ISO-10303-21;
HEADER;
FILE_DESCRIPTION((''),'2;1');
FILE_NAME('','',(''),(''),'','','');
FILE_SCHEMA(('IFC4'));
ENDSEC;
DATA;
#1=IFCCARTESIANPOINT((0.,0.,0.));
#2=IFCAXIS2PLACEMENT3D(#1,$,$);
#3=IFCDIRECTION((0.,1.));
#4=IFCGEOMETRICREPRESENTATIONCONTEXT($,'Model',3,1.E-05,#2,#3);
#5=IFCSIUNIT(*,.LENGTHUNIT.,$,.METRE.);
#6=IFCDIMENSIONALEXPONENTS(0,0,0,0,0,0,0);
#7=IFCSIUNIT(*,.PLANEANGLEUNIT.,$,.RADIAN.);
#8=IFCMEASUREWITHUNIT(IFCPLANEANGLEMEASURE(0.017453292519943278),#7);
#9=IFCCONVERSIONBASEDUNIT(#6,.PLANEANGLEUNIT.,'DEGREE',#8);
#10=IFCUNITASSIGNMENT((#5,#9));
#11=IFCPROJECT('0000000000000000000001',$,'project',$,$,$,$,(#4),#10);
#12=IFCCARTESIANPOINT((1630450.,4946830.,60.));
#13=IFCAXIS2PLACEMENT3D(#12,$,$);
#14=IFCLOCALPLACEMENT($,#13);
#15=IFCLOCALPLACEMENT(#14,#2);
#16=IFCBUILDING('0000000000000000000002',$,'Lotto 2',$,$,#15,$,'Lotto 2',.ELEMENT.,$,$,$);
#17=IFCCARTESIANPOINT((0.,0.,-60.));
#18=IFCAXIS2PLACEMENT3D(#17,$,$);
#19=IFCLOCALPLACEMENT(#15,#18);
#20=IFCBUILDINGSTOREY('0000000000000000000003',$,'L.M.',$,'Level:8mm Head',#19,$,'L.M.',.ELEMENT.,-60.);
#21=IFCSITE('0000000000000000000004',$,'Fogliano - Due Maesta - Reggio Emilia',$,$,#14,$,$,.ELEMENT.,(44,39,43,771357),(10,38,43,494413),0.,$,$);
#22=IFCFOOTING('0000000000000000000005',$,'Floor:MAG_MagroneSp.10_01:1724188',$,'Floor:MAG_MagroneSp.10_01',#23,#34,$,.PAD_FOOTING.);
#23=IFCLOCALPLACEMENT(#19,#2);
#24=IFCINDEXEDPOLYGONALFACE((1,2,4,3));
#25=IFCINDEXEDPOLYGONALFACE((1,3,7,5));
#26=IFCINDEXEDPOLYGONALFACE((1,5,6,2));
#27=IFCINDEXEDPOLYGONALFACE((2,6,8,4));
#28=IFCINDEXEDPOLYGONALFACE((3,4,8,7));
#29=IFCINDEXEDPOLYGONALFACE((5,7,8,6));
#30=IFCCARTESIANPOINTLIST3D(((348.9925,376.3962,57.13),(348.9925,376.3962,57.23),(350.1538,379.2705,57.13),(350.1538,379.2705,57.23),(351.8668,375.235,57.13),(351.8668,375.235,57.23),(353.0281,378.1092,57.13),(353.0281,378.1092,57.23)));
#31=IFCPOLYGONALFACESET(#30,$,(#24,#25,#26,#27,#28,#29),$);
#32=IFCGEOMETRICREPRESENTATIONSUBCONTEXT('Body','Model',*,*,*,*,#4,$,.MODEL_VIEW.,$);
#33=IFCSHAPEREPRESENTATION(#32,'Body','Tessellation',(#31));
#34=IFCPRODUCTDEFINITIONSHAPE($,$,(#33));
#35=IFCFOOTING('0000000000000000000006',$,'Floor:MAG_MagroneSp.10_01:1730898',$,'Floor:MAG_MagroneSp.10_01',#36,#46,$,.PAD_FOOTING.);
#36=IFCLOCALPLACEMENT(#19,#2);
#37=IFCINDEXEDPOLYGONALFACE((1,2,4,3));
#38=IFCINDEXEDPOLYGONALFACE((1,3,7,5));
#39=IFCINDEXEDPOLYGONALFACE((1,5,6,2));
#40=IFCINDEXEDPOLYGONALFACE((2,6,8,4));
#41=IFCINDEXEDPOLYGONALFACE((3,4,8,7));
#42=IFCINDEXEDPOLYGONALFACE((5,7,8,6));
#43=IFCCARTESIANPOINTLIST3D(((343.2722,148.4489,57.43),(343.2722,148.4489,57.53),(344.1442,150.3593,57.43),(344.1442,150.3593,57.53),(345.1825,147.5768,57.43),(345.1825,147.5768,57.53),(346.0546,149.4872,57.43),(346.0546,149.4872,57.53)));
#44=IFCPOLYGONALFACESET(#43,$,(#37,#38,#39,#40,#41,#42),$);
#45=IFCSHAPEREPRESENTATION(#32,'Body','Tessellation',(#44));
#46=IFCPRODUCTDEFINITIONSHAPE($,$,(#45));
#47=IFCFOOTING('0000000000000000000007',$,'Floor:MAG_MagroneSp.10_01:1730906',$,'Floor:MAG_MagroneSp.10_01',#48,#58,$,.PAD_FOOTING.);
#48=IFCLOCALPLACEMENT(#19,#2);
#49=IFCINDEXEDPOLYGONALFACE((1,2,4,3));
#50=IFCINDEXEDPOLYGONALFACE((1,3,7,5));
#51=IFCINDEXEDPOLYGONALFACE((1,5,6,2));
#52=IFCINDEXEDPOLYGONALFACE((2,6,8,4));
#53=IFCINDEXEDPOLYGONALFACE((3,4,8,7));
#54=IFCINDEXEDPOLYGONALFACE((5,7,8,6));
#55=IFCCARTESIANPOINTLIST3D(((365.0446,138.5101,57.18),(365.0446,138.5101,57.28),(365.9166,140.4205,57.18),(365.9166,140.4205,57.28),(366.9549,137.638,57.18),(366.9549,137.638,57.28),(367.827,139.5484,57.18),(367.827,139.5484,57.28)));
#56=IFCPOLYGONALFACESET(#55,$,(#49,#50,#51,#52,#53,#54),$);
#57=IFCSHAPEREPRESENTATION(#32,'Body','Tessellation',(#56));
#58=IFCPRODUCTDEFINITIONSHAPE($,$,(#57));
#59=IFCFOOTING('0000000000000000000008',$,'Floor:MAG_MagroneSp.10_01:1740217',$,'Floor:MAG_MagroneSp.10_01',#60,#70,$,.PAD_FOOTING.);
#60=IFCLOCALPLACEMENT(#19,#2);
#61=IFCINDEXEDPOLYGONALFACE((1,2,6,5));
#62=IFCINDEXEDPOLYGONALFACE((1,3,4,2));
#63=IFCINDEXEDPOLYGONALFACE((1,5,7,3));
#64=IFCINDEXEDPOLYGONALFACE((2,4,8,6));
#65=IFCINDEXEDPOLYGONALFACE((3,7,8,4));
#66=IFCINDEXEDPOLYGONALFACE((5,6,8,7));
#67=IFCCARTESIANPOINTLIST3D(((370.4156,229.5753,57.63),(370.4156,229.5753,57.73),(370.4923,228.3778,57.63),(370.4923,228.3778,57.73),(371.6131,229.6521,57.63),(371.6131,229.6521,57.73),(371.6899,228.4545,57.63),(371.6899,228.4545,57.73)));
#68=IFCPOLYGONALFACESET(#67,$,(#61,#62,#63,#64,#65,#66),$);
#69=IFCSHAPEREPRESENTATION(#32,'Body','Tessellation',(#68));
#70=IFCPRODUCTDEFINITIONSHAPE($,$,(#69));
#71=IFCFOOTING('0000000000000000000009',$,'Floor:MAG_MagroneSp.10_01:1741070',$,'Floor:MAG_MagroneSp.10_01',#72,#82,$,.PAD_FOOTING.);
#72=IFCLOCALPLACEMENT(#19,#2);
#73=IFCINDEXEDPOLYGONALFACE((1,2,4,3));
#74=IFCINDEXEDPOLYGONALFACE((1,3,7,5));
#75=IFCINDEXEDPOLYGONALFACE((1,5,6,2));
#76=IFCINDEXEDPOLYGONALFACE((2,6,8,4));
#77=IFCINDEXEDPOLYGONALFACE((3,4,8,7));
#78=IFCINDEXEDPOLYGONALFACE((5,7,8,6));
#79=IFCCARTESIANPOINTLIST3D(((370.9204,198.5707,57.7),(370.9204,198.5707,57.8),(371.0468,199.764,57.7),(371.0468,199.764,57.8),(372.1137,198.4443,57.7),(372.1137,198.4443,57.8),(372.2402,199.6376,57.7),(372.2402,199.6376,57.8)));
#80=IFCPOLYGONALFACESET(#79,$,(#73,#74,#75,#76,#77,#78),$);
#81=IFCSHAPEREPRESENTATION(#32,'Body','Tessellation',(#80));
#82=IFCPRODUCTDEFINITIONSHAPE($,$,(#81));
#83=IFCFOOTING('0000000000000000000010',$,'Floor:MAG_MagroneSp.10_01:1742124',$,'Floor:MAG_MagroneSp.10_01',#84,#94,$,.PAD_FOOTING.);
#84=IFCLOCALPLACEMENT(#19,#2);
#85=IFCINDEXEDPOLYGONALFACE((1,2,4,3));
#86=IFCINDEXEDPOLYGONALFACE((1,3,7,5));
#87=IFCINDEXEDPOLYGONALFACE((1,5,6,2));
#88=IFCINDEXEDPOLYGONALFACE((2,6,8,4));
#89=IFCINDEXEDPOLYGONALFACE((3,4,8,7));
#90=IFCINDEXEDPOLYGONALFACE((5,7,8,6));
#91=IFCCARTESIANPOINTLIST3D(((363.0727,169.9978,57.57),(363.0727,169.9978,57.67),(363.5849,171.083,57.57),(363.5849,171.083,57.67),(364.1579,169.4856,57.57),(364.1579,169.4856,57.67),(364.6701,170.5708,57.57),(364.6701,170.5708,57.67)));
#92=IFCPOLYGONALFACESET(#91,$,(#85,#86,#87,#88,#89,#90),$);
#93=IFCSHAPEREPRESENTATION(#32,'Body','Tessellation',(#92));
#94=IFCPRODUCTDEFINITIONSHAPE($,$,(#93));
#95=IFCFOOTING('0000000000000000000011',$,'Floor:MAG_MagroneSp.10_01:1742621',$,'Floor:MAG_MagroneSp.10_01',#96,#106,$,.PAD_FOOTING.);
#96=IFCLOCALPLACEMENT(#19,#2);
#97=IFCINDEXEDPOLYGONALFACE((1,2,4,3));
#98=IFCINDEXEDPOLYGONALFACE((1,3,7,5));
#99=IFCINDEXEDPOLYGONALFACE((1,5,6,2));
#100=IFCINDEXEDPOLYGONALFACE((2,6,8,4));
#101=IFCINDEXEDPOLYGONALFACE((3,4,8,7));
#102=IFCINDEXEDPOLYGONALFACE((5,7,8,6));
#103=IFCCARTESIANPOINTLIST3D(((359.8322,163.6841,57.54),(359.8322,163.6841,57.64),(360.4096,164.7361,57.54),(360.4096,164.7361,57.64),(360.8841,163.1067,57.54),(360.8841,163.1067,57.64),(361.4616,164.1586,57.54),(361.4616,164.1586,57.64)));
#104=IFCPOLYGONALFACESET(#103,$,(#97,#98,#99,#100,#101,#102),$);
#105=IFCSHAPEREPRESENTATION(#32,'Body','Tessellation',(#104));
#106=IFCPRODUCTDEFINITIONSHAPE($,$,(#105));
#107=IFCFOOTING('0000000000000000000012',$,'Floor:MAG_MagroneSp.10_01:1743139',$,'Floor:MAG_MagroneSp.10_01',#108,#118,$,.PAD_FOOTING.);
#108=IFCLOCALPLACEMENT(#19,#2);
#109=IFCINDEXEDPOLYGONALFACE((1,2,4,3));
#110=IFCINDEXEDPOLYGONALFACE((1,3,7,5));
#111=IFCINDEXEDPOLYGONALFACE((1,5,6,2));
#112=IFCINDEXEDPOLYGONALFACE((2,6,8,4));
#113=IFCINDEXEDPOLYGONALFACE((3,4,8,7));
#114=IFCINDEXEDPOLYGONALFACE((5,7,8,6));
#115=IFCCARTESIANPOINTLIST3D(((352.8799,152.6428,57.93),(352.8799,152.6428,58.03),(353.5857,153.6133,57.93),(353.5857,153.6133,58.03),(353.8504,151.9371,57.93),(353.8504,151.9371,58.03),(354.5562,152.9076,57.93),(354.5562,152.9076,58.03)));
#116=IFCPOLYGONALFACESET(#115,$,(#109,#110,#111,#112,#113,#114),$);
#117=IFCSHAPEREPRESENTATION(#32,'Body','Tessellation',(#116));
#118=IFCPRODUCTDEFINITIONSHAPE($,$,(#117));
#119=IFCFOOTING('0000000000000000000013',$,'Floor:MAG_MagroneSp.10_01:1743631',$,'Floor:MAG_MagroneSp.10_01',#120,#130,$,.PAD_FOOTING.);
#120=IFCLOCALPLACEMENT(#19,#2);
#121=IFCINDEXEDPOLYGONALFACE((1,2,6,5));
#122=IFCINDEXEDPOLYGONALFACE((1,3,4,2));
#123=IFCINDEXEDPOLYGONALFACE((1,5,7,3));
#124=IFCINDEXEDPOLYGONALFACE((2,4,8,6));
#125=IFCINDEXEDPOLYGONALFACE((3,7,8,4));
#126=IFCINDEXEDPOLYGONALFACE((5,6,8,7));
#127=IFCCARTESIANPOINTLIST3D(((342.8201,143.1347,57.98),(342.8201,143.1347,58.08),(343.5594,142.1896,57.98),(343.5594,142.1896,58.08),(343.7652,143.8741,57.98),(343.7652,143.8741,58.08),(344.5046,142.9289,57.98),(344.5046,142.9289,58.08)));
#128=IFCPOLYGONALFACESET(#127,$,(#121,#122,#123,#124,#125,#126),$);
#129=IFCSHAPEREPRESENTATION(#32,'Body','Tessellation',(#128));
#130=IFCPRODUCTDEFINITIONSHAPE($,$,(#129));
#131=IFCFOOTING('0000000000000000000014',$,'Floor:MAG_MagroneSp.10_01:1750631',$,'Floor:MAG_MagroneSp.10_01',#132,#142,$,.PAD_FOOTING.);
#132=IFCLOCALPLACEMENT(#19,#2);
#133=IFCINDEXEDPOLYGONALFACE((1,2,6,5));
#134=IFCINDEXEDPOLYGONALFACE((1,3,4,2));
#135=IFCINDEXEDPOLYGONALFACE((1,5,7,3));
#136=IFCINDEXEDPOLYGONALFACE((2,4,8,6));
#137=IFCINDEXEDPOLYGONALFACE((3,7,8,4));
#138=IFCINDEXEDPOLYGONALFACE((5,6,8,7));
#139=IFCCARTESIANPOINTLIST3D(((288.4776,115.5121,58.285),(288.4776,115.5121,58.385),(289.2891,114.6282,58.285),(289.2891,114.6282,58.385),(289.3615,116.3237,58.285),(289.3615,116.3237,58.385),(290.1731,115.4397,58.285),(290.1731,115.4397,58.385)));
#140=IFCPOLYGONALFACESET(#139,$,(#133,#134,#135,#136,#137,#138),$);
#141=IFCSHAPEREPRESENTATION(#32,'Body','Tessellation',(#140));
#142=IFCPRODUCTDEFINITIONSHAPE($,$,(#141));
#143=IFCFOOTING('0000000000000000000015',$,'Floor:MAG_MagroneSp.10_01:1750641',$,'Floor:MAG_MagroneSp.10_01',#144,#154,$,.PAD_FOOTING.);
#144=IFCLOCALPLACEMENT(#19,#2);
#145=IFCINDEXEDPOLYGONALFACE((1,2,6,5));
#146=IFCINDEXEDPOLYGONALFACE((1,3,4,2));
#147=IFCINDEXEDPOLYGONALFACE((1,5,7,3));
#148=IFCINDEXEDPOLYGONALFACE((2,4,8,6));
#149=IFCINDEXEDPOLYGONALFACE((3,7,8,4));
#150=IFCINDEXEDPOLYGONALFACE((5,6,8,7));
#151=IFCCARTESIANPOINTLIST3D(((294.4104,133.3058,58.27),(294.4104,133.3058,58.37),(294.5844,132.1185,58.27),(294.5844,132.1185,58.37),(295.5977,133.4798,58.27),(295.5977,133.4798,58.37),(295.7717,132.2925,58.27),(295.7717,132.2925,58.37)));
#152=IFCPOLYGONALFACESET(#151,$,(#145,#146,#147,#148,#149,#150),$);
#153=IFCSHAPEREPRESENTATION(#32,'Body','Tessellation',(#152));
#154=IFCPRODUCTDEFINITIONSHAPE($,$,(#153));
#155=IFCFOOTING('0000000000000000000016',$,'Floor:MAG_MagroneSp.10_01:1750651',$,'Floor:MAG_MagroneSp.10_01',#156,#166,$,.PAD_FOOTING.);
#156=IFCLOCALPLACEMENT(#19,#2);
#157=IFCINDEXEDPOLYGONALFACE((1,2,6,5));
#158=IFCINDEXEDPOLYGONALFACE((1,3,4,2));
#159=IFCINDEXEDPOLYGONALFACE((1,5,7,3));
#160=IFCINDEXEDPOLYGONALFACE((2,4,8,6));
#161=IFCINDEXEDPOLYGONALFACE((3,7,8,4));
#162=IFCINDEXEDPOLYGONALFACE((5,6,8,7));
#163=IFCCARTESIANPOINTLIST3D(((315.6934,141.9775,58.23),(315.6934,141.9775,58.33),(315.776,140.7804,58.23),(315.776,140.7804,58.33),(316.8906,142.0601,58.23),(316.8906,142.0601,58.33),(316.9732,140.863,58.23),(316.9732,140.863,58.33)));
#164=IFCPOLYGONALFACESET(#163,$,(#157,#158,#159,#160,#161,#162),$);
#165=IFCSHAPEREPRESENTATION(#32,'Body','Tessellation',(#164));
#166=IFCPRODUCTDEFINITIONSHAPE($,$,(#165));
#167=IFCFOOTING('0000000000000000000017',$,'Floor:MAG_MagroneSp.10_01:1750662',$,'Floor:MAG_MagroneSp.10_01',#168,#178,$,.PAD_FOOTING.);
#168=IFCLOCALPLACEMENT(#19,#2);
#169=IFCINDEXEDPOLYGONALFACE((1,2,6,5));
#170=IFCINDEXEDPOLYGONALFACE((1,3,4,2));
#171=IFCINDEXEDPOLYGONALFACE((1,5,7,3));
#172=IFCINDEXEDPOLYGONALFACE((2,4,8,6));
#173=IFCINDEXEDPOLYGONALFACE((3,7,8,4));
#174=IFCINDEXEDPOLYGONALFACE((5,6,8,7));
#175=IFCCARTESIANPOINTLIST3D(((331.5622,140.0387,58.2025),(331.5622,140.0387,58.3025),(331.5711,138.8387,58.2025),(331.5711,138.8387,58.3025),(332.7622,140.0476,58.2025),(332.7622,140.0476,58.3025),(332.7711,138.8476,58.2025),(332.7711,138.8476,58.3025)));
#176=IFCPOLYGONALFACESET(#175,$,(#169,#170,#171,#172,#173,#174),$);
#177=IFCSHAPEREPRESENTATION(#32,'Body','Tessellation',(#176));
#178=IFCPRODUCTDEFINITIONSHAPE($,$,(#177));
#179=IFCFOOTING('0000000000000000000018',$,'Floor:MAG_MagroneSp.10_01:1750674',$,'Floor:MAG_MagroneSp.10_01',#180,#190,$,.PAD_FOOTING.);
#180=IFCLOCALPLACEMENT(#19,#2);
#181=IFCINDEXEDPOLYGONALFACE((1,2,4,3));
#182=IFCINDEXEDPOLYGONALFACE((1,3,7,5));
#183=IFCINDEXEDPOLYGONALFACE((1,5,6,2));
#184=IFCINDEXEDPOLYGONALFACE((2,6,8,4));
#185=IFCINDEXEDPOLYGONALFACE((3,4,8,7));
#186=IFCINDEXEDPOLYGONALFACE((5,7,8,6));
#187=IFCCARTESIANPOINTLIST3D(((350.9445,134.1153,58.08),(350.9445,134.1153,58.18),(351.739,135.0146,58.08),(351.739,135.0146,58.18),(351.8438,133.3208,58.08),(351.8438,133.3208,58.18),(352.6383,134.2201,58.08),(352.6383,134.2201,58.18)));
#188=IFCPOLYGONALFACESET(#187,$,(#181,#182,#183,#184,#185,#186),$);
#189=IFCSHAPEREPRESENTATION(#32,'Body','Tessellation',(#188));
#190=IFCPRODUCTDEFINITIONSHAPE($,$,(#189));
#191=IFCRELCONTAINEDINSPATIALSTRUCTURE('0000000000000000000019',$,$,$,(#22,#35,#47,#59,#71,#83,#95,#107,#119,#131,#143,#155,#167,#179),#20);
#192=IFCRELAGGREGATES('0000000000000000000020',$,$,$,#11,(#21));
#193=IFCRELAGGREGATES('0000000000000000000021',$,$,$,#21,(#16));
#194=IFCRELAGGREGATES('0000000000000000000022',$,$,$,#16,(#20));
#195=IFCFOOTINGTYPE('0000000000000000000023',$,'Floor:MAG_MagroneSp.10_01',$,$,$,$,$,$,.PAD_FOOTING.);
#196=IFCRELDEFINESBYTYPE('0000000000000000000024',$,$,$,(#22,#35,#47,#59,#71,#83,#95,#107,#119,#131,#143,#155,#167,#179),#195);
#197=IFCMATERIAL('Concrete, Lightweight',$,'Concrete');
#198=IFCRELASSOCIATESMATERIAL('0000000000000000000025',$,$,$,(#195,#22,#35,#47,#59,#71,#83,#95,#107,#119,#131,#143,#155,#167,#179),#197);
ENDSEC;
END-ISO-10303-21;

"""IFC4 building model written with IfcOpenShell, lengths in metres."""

from ifc_helpers import new_model, entity, si_unit, converted_unit, direction, frame, origin, place, context, subcontext, project, spatial, indexed_curve, outline, extrude, material, type_object, element, save


model = new_model("IFC4")

# Units and contexts
model_context = context("Model", 3, precision=1e-05, world=origin(), true_north=direction((0.0, 1.0)))
body_context = subcontext(model_context, "Body", "Model", "MODEL_VIEW")
ifc_project = project(units=[si_unit("LENGTHUNIT", "METRE"), converted_unit("PLANEANGLEUNIT", "DEGREE", entity("IfcPlaneAngleMeasure", 0.017453292519943278), si_unit("PLANEANGLEUNIT", "RADIAN"), dimensions=[0, 0, 0, 0, 0, 0, 0])], contexts=[model_context])

# Site, building, storey
site_placement = place(None, frame((1630450.0, 4946830.0, 60.0)))
site = spatial("IfcSite", under=ifc_project, at=site_placement, Name="Fogliano - Due Maesta - Reggio Emilia", CompositionType="ELEMENT", RefLatitude=(44, 39, 43, 771357), RefLongitude=(10, 38, 43, 494413), RefElevation=0.0)
building_placement = place(site_placement, origin())
building = spatial("IfcBuilding", under=site, at=building_placement, Name="Lotto 2", LongName="Lotto 2", CompositionType="ELEMENT")
storey_placement = place(building_placement, frame((0.0, 0.0, -60.0)))
storey = spatial("IfcBuildingStorey", under=building, at=storey_placement, Name="L.M.", ObjectType="Level:8mm Head", LongName="L.M.", CompositionType="ELEMENT", Elevation=-60.0)

# Footings
ifc_material = material(Name="Concrete, Lightweight", Category="Concrete")
footing_type = type_object("IfcFootingType", Name="Floor:MAG_MagroneSp.10_01", PredefinedType="PAD_FOOTING", material=ifc_material)
footing_1_placement = place(storey_placement, origin())
element("IfcFooting", 1, at=footing_1_placement, inside=storey, type_object=footing_type, material=ifc_material, Name="Floor:MAG_MagroneSp.10_01:1724188", ObjectType="Floor:MAG_MagroneSp.10_01", PredefinedType="PAD_FOOTING", context=body_context, shape_type="SweptSolid", body=[
    extrude(outline(indexed_curve([(-1.55, -1.55), (1.55, -1.55), (1.55, 1.55), (-1.55, 1.55), (-1.55, -1.55)], self_intersect=False)), frame((351.0103, 377.2527, 57.23), z_axis=(0.0, 0.0, -1.0), x_axis=(0.927184, -0.374607, 0.0)), (0.0, 0.0, 1.0), 0.1),
])
footing_2_placement = place(storey_placement, origin())
element("IfcFooting", 2, at=footing_2_placement, inside=storey, type_object=footing_type, material=ifc_material, Name="Floor:MAG_MagroneSp.10_01:1730898", ObjectType="Floor:MAG_MagroneSp.10_01", PredefinedType="PAD_FOOTING", context=body_context, shape_type="SweptSolid", body=[
    extrude(outline(indexed_curve([(-1.05, -1.05), (1.05, -1.05), (1.05, 1.05), (-1.05, 1.05), (-1.05, -1.05)], self_intersect=False)), frame((344.6634, 148.968, 57.53), z_axis=(0.0, 0.0, -1.0), x_axis=(-0.415265, -0.9097, 0.0)), (0.0, 0.0, 1.0), 0.1),
])
footing_3_placement = place(storey_placement, origin())
element("IfcFooting", 3, at=footing_3_placement, inside=storey, type_object=footing_type, material=ifc_material, Name="Floor:MAG_MagroneSp.10_01:1730906", ObjectType="Floor:MAG_MagroneSp.10_01", PredefinedType="PAD_FOOTING", context=body_context, shape_type="SweptSolid", body=[
    extrude(outline(indexed_curve([(-1.05, -1.05), (1.05, -1.05), (1.05, 1.05), (-1.05, 1.05), (-1.05, -1.05)], self_intersect=False)), frame((366.4358, 139.0293, 57.28), z_axis=(0.0, 0.0, -1.0), x_axis=(-0.415265, -0.9097, 0.0)), (0.0, 0.0, 1.0), 0.1),
])
footing_4_placement = place(storey_placement, origin())
element("IfcFooting", 4, at=footing_4_placement, inside=storey, type_object=footing_type, material=ifc_material, Name="Floor:MAG_MagroneSp.10_01:1740217", ObjectType="Floor:MAG_MagroneSp.10_01", PredefinedType="PAD_FOOTING", context=body_context, shape_type="SweptSolid", body=[
    extrude(outline(indexed_curve([(-0.6, -0.6), (0.6, -0.6), (0.6, 0.6), (-0.6, 0.6), (-0.6, -0.6)], self_intersect=False)), frame((371.0527, 229.0149, 57.73), z_axis=(0.0, 0.0, -1.0), x_axis=(0.997952, 0.063964, 0.0)), (0.0, 0.0, 1.0), 0.1),
])
footing_5_placement = place(storey_placement, origin())
element("IfcFooting", 5, at=footing_5_placement, inside=storey, type_object=footing_type, material=ifc_material, Name="Floor:MAG_MagroneSp.10_01:1741070", ObjectType="Floor:MAG_MagroneSp.10_01", PredefinedType="PAD_FOOTING", context=body_context, shape_type="SweptSolid", body=[
    extrude(outline(indexed_curve([(-0.6, -0.6), (0.6, -0.6), (0.6, 0.6), (-0.6, 0.6), (-0.6, -0.6)], self_intersect=False)), frame((371.5803, 199.1042, 57.8), z_axis=(0.0, 0.0, -1.0), x_axis=(0.994436, -0.105345, 0.0)), (0.0, 0.0, 1.0), 0.1),
])
footing_6_placement = place(storey_placement, origin())
element("IfcFooting", 6, at=footing_6_placement, inside=storey, type_object=footing_type, material=ifc_material, Name="Floor:MAG_MagroneSp.10_01:1742124", ObjectType="Floor:MAG_MagroneSp.10_01", PredefinedType="PAD_FOOTING", context=body_context, shape_type="SweptSolid", body=[
    extrude(outline(indexed_curve([(-0.6, -0.6), (0.6, -0.6), (0.6, 0.6), (-0.6, 0.6), (-0.6, -0.6)], self_intersect=False)), frame((363.8714, 170.2843, 57.67), z_axis=(0.0, 0.0, -1.0), x_axis=(0.90432, -0.426855, 0.0)), (0.0, 0.0, 1.0), 0.1),
])
footing_7_placement = place(storey_placement, origin())
element("IfcFooting", 7, at=footing_7_placement, inside=storey, type_object=footing_type, material=ifc_material, Name="Floor:MAG_MagroneSp.10_01:1742621", ObjectType="Floor:MAG_MagroneSp.10_01", PredefinedType="PAD_FOOTING", context=body_context, shape_type="SweptSolid", body=[
    extrude(outline(indexed_curve([(-0.6, -0.6), (0.6, -0.6), (0.6, 0.6), (-0.6, 0.6), (-0.6, -0.6)], self_intersect=False)), frame((360.6469, 163.9214, 57.64), z_axis=(0.0, 0.0, -1.0), x_axis=(0.876613, -0.481196, 0.0)), (0.0, 0.0, 1.0), 0.1),
])
footing_8_placement = place(storey_placement, origin())
element("IfcFooting", 8, at=footing_8_placement, inside=storey, type_object=footing_type, material=ifc_material, Name="Floor:MAG_MagroneSp.10_01:1743139", ObjectType="Floor:MAG_MagroneSp.10_01", PredefinedType="PAD_FOOTING", context=body_context, shape_type="SweptSolid", body=[
    extrude(outline(indexed_curve([(-0.6, -0.6), (0.6, -0.6), (0.6, 0.6), (-0.6, 0.6), (-0.6, -0.6)], self_intersect=False)), frame((353.7181, 152.7752, 58.03), z_axis=(0.0, 0.0, -1.0), x_axis=(0.808749, -0.588154, 0.0)), (0.0, 0.0, 1.0), 0.1),
])
footing_9_placement = place(storey_placement, origin())
element("IfcFooting", 9, at=footing_9_placement, inside=storey, type_object=footing_type, material=ifc_material, Name="Floor:MAG_MagroneSp.10_01:1743631", ObjectType="Floor:MAG_MagroneSp.10_01", PredefinedType="PAD_FOOTING", context=body_context, shape_type="SweptSolid", body=[
    extrude(outline(indexed_curve([(-0.6, -0.6), (0.6, -0.6), (0.6, 0.6), (-0.6, 0.6), (-0.6, -0.6)], self_intersect=False)), frame((343.6623, 143.0318, 58.08), z_axis=(0.0, 0.0, -1.0), x_axis=(0.616139, -0.787638, 0.0)), (0.0, 0.0, 1.0), 0.1),
])
footing_10_placement = place(storey_placement, origin())
element("IfcFooting", 10, at=footing_10_placement, inside=storey, type_object=footing_type, material=ifc_material, Name="Floor:MAG_MagroneSp.10_01:1750631", ObjectType="Floor:MAG_MagroneSp.10_01", PredefinedType="PAD_FOOTING", context=body_context, shape_type="SweptSolid", body=[
    extrude(outline(indexed_curve([(-0.6, -0.6), (0.6, -0.6), (0.6, 0.6), (-0.6, 0.6), (-0.6, -0.6)], self_intersect=False)), frame((289.3253, 115.4759, 58.385), z_axis=(0.0, 0.0, -1.0), x_axis=(0.676279, -0.736646, 0.0)), (0.0, 0.0, 1.0), 0.1),
])
footing_11_placement = place(storey_placement, origin())
element("IfcFooting", 11, at=footing_11_placement, inside=storey, type_object=footing_type, material=ifc_material, Name="Floor:MAG_MagroneSp.10_01:1750641", ObjectType="Floor:MAG_MagroneSp.10_01", PredefinedType="PAD_FOOTING", context=body_context, shape_type="SweptSolid", body=[
    extrude(outline(indexed_curve([(-0.6, -0.6), (0.6, -0.6), (0.6, 0.6), (-0.6, 0.6), (-0.6, -0.6)], self_intersect=False)), frame((295.091, 132.7991, 58.37), z_axis=(0.0, 0.0, -1.0), x_axis=(0.144985, -0.989434, 0.0)), (0.0, 0.0, 1.0), 0.1),
])
footing_12_placement = place(storey_placement, origin())
element("IfcFooting", 12, at=footing_12_placement, inside=storey, type_object=footing_type, material=ifc_material, Name="Floor:MAG_MagroneSp.10_01:1750651", ObjectType="Floor:MAG_MagroneSp.10_01", PredefinedType="PAD_FOOTING", context=body_context, shape_type="SweptSolid", body=[
    extrude(outline(indexed_curve([(-0.6, -0.6), (0.6, -0.6), (0.6, 0.6), (-0.6, 0.6), (-0.6, -0.6)], self_intersect=False)), frame((316.3333, 141.4202, 58.33), z_axis=(0.0, 0.0, -1.0), x_axis=(0.06882, -0.997629, 0.0)), (0.0, 0.0, 1.0), 0.1),
])
footing_13_placement = place(storey_placement, origin())
element("IfcFooting", 13, at=footing_13_placement, inside=storey, type_object=footing_type, material=ifc_material, Name="Floor:MAG_MagroneSp.10_01:1750662", ObjectType="Floor:MAG_MagroneSp.10_01", PredefinedType="PAD_FOOTING", context=body_context, shape_type="SweptSolid", body=[
    extrude(outline(indexed_curve([(-0.6, -0.6), (0.6, -0.6), (0.6, 0.6), (-0.6, 0.6), (-0.6, -0.6)], self_intersect=False)), frame((332.1666, 139.4431, 58.3025), z_axis=(0.0, 0.0, -1.0), x_axis=(0.007408, -0.999973, 0.0)), (0.0, 0.0, 1.0), 0.1),
])
footing_14_placement = place(storey_placement, origin())
element("IfcFooting", 14, at=footing_14_placement, inside=storey, type_object=footing_type, material=ifc_material, Name="Floor:MAG_MagroneSp.10_01:1750674", ObjectType="Floor:MAG_MagroneSp.10_01", PredefinedType="PAD_FOOTING", context=body_context, shape_type="SweptSolid", body=[
    extrude(outline(indexed_curve([(-0.6, -0.6), (0.6, -0.6), (0.6, 0.6), (-0.6, 0.6), (-0.6, -0.6)], self_intersect=False)), frame((351.7914, 134.1677, 58.18), z_axis=(0.0, 0.0, -1.0), x_axis=(-0.662089, -0.749426, 0.0)), (0.0, 0.0, 1.0), 0.1),
])

save(model, "model.ifc")
